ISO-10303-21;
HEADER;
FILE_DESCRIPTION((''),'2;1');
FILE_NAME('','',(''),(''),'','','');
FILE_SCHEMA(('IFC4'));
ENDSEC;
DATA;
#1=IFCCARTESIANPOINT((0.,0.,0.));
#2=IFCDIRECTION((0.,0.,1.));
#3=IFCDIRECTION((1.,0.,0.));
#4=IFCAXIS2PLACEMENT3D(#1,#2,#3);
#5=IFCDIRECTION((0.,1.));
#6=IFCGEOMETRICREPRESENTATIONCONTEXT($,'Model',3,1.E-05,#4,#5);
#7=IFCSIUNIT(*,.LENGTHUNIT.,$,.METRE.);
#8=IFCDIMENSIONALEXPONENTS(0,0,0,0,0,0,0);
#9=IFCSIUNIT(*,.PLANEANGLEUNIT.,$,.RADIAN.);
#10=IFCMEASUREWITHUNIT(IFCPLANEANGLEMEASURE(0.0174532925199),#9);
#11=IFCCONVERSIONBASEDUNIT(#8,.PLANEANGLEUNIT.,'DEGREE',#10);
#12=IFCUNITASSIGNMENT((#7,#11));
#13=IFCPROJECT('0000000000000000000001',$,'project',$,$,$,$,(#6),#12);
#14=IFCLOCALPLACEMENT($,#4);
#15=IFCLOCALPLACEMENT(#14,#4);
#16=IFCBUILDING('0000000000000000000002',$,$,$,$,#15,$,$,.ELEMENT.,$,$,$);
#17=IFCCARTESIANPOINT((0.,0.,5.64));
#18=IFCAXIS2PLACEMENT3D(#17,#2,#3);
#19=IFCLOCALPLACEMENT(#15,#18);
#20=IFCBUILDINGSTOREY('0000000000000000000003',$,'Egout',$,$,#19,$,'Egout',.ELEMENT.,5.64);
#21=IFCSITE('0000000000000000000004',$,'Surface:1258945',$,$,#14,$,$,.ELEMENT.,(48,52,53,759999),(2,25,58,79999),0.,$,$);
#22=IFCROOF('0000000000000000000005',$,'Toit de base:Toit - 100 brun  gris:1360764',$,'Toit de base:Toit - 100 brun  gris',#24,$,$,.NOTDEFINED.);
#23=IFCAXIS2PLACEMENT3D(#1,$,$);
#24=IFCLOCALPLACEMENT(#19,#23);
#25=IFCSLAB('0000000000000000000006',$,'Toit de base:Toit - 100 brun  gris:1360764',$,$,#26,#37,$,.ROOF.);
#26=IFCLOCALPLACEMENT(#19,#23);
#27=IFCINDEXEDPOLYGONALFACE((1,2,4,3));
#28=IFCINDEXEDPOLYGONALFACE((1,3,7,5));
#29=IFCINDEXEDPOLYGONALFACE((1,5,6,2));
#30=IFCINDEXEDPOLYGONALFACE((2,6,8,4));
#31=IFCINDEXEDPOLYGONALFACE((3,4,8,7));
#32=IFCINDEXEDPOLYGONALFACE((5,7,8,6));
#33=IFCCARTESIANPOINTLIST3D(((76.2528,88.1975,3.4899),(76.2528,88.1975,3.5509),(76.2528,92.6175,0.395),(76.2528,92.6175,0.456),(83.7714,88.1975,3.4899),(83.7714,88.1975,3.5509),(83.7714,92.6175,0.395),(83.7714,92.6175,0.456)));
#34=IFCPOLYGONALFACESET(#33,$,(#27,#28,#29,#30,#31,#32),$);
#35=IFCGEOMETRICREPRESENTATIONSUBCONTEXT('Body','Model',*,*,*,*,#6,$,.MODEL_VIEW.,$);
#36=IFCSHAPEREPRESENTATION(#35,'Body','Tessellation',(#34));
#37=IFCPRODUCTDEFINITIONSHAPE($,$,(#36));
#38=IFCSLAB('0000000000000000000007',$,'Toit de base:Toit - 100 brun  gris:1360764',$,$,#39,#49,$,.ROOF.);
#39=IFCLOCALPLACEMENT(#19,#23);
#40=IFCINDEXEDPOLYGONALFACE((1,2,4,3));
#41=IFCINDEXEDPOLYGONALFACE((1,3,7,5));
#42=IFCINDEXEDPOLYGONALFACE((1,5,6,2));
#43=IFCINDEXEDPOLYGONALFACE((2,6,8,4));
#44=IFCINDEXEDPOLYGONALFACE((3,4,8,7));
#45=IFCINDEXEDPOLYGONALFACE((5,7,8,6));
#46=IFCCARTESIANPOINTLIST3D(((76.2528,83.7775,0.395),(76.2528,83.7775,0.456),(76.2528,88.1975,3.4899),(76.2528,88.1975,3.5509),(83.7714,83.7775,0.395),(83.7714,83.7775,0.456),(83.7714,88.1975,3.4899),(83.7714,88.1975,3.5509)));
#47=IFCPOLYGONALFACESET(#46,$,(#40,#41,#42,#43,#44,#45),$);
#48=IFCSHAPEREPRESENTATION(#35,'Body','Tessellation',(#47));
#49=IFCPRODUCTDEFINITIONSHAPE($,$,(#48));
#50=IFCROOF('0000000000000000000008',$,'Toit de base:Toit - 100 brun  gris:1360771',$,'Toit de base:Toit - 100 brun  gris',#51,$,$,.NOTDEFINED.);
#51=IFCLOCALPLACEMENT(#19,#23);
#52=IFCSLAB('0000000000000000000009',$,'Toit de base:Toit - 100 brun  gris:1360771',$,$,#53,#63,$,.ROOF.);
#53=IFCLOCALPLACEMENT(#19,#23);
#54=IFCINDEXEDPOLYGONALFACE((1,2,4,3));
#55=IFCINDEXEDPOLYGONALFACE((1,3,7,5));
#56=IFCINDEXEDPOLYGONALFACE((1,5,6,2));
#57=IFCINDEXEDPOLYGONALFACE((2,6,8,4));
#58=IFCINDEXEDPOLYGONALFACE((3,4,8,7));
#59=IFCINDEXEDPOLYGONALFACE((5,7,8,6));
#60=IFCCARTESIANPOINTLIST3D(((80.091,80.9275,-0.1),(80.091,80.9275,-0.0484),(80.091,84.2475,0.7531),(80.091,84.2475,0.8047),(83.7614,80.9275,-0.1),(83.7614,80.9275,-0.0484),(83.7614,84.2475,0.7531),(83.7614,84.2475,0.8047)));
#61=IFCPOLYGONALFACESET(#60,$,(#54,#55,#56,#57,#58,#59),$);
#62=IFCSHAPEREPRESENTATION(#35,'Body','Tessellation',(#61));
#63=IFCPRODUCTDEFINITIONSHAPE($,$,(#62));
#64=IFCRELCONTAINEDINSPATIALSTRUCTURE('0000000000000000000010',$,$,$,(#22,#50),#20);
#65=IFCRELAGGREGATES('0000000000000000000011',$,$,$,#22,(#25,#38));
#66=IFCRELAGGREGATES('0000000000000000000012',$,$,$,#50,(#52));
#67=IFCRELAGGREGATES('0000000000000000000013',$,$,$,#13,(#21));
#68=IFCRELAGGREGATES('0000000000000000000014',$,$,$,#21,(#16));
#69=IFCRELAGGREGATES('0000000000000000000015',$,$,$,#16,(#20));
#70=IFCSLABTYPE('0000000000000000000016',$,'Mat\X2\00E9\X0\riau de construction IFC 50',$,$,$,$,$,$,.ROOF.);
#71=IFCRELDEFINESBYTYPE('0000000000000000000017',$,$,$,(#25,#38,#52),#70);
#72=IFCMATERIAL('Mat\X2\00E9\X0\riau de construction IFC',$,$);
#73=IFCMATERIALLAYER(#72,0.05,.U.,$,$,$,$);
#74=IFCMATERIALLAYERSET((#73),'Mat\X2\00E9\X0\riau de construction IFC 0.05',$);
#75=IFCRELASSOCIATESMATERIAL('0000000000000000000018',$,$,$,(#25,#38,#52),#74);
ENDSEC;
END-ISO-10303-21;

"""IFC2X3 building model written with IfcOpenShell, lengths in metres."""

from ifc_helpers import new_model, entity, si_unit, converted_unit, direction, frame, origin_with_axes, place, context, subcontext, project, spatial, polyline, outline, extrude, material, layer, layer_set, layer_usage, type_object, element, aggregate, save


model = new_model("IFC2X3")

# Units and contexts
model_context = context("Model", 3, precision=1e-05, world=origin_with_axes(), true_north=direction((0.0, 1.0)))
body_context = subcontext(model_context, "Body", "Model", "MODEL_VIEW")
ifc_project = project(units=[si_unit("LENGTHUNIT", "METRE"), converted_unit("PLANEANGLEUNIT", "DEGREE", entity("IfcPlaneAngleMeasure", 0.0174532925199), si_unit("PLANEANGLEUNIT", "RADIAN"), dimensions=[0, 0, 0, 0, 0, 0, 0])], contexts=[model_context])

# Site, building, storey
site_placement = place(None, origin_with_axes())
site = spatial("IfcSite", under=ifc_project, at=site_placement, Name="Surface:1258945", CompositionType="ELEMENT", RefLatitude=(48, 52, 53, 759999), RefLongitude=(2, 25, 58, 79999), RefElevation=0.0)
building_placement = place(site_placement, origin_with_axes())
building = spatial("IfcBuilding", under=site, at=building_placement, CompositionType="ELEMENT")
storey_placement = place(building_placement, frame((0.0, 0.0, 5.64), z_axis=(0.0, 0.0, 1.0), x_axis=(1.0, 0.0, 0.0)))
storey = spatial("IfcBuildingStorey", under=building, at=storey_placement, Name="Egout", LongName="Egout", CompositionType="ELEMENT", Elevation=5.64)

# Shared definitions
ifc_material_1 = material(Name="Matériau de construction IFC")
ifc_layer = layer(ifc_material_1, 0.05, ventilated="UNKNOWN")
ifc_layer_set = layer_set([ifc_layer], Name="Matériau de construction IFC 0.05")
slab_type = type_object("IfcSlabType", Name="Matériau de construction IFC 50", PredefinedType="ROOF")

# Roof, slabs
roof_1_placement = place(storey_placement, frame((0.0, 0.0, -5.64), z_axis=(0.0, 0.0, 1.0), x_axis=(1.0, 0.0, 0.0)))
roof_1 = element("IfcRoof", 1, at=roof_1_placement, inside=storey, Name="Toit de base:Toit - 100 brun  gris:1360764", ObjectType="Toit de base:Toit - 100 brun  gris", ShapeType="NOTDEFINED")
ifc_layer_usage_1 = layer_usage(ifc_layer_set, "AXIS3", "NEGATIVE", 0.05)
slab_1_placement = place(roof_1_placement, frame((83.7714, 90.4075, 7.5824), z_axis=(0.0, 0.0, 1.0), x_axis=(-1.0, 0.0, 0.0)))
slab_1 = element("IfcSlab", 2, at=slab_1_placement, type_object=slab_type, material=ifc_layer_usage_1, Name="Toit de base:Toit - 100 brun  gris:1360764", PredefinedType="ROOF", context=body_context, shape_type="SweptSolid", body=[
    extrude(outline(polyline([(0.0, 2.6979), (0.0, -2.6979), (7.5186, -2.6979), (7.5186, 2.6979), (0.0, 2.6979)])), frame((0.0, 0.0, 0.0), z_axis=(0.0, -0.573576, 0.819152), x_axis=(1.0, 0.0, 0.0)), (0.0, 0.573576, 0.819152), 0.061),
])
ifc_layer_usage_2 = layer_usage(ifc_layer_set, "AXIS3", "NEGATIVE", 0.05)
slab_2_placement = place(roof_1_placement, frame((76.2528, 85.9875, 7.5824), z_axis=(0.0, 0.0, 1.0), x_axis=(1.0, 0.0, 0.0)))
slab_2 = element("IfcSlab", 3, at=slab_2_placement, type_object=slab_type, material=ifc_layer_usage_2, Name="Toit de base:Toit - 100 brun  gris:1360764", PredefinedType="ROOF", context=body_context, shape_type="SweptSolid", body=[
    extrude(outline(polyline([(7.5186, 2.6979), (0.0, 2.6979), (0.0, -2.6979), (7.5186, -2.6979), (7.5186, 2.6979)])), frame((0.0, 0.0, 0.0), z_axis=(0.0, -0.573576, 0.819152), x_axis=(1.0, 0.0, 0.0)), (0.0, 0.573576, 0.819152), 0.061),
])
aggregate(roof_1, [slab_1, slab_2])

# Roof, slab
roof_2_placement = place(storey_placement, frame((0.0, 0.0, -5.64), z_axis=(0.0, 0.0, 1.0), x_axis=(1.0, 0.0, 0.0)))
roof_2 = element("IfcRoof", 4, at=roof_2_placement, inside=storey, Name="Toit de base:Toit - 100 brun  gris:1360771", ObjectType="Toit de base:Toit - 100 brun  gris", ShapeType="NOTDEFINED")
ifc_layer_usage_3 = layer_usage(ifc_layer_set, "AXIS3", "NEGATIVE", 0.05)
slab_3_placement = place(roof_2_placement, frame((80.091, 82.5875, 5.9665), z_axis=(0.0, 0.0, 1.0), x_axis=(1.0, 0.0, 0.0)))
slab_3 = element("IfcSlab", 5, at=slab_3_placement, type_object=slab_type, material=ifc_layer_usage_3, Name="Toit de base:Toit - 100 brun  gris:1360771", PredefinedType="ROOF", context=body_context, shape_type="SweptSolid", body=[
    extrude(outline(polyline([(0.0, 1.7139), (0.0, -1.7139), (3.6704, -1.7139), (3.6704, 1.7139), (0.0, 1.7139)])), frame((0.0, 0.0, 0.0), z_axis=(0.0, -0.248865, 0.968538), x_axis=(1.0, 0.0, 0.0)), (0.0, 0.248865, 0.968538), 0.0516),
])
aggregate(roof_2, [slab_3])

save(model, "model.ifc")
